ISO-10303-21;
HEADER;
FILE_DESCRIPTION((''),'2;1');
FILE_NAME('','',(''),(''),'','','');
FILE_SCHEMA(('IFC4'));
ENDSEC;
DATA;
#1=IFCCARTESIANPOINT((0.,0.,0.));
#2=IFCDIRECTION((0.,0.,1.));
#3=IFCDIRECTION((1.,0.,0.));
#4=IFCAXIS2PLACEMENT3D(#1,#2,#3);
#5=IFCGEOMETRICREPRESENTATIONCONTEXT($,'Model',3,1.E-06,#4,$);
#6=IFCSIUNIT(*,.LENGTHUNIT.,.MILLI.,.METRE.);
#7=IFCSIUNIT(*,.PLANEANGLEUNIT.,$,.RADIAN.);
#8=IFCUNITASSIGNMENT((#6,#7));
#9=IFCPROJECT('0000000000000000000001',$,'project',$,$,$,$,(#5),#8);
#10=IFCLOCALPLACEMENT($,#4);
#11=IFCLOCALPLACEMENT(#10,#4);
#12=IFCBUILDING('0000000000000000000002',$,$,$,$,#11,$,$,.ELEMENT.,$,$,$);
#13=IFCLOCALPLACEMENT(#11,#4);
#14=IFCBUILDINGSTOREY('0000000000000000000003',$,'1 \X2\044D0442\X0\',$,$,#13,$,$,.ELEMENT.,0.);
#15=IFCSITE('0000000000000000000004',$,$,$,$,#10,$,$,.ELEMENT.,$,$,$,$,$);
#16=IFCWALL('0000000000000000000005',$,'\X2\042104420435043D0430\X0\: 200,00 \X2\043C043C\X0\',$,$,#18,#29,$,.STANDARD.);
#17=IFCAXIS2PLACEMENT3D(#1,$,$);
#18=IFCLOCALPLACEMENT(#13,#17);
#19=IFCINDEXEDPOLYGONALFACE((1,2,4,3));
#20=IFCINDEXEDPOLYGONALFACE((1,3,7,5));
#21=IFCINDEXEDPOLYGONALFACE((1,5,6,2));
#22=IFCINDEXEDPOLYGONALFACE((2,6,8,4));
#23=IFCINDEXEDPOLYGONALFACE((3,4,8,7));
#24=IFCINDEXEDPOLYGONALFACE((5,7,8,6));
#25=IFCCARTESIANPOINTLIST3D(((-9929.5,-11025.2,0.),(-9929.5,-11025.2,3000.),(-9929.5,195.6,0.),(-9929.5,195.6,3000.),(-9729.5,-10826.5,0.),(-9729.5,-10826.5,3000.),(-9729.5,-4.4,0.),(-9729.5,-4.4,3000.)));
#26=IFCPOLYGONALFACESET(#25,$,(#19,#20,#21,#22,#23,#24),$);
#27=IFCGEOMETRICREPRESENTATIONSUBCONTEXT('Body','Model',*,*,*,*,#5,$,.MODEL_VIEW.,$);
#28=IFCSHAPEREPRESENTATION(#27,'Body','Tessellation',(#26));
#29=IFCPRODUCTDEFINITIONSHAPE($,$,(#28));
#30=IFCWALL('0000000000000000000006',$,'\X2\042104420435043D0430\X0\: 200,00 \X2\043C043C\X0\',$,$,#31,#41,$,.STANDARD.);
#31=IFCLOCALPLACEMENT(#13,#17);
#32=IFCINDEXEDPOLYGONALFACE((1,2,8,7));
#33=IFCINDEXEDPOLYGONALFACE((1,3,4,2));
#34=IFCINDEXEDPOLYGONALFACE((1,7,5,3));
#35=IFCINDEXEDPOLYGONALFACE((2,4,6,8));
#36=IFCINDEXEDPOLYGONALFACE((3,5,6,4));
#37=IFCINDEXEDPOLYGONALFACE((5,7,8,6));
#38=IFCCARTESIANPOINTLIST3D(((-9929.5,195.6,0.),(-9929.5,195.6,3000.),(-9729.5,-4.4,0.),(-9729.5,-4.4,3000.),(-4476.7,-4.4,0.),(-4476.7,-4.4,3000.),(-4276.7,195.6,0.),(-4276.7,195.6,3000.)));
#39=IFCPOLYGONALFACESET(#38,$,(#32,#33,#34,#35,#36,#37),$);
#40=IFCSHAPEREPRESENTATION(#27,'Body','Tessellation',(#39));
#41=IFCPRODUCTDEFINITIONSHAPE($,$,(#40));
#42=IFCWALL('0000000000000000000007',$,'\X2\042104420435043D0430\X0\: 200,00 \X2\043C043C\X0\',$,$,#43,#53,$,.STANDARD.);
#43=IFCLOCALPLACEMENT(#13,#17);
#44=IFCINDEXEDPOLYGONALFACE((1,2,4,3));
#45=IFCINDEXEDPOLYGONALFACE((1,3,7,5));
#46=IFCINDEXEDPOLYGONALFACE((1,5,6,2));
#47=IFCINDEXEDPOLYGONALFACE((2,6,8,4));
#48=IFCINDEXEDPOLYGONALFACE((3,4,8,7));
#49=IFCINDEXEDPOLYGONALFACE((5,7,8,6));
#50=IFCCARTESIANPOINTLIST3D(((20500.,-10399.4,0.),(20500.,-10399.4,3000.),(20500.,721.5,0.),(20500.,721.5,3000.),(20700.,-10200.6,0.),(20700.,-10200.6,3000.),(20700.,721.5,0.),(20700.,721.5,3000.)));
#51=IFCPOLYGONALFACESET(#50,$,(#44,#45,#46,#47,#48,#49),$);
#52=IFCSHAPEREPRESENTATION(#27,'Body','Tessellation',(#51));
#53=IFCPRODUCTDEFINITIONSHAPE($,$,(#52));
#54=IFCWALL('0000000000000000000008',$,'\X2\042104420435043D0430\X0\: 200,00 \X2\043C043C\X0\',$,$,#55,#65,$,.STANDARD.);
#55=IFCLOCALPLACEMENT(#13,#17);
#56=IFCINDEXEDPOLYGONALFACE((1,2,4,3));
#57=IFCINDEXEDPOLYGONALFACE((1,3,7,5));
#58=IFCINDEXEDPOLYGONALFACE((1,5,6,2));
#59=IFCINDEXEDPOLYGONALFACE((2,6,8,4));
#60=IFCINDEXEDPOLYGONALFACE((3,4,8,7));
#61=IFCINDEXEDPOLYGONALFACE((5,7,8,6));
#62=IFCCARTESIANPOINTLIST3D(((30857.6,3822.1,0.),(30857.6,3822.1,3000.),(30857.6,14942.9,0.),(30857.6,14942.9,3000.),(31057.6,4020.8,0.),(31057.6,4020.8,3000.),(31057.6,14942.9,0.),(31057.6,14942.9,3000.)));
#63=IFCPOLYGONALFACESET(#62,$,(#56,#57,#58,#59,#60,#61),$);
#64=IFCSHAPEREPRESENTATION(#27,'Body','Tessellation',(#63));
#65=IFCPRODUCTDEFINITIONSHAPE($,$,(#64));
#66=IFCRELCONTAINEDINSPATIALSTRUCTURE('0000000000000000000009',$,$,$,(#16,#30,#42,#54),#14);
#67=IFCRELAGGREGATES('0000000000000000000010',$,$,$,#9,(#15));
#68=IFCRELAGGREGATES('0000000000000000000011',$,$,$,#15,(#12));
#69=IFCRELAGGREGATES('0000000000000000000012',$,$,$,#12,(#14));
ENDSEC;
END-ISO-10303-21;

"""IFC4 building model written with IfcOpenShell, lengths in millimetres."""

from ifc_helpers import new_model, si_unit, frame, origin_with_axes, place, context, subcontext, project, spatial, line, indexed_curve, outline, extrude, source, transform, mapped, element, save


model = new_model("IFC4")

# Units and contexts
model_context = context("Model", 3, precision=1e-06, world=origin_with_axes())
body_context = subcontext(model_context, "Body", "Model", "MODEL_VIEW")
ifc_project = project(units=[si_unit("LENGTHUNIT", "METRE", prefix="MILLI"), si_unit("PLANEANGLEUNIT", "RADIAN")], contexts=[model_context])

# Site, building, storey
site_placement = place(None, origin_with_axes())
site = spatial("IfcSite", under=ifc_project, at=site_placement, CompositionType="ELEMENT")
building_placement = place(site_placement, origin_with_axes())
building = spatial("IfcBuilding", under=site, at=building_placement, CompositionType="ELEMENT")
storey_placement = place(building_placement, origin_with_axes())
storey = spatial("IfcBuildingStorey", under=building, at=storey_placement, Name="1 эт", CompositionType="ELEMENT", Elevation=0.0)

# Walls
shared_shape_1 = source(origin_with_axes(), body_context, "Body", "SweptSolid", [
    extrude(outline(indexed_curve([(99.4, -100.0), (10921.5, -100.0), (11121.5, 100.0), (-99.4, 100.0)], segments=[line(1, 2), line(2, 3), line(3, 4), line(4, 1)])), origin_with_axes(), (0.0, 0.0, 1.0), 3000.0),
])
wall_1_placement = place(storey_placement, frame((-9829.5, -10925.9, 0.0), z_axis=(0.0, 0.0, 1.0), x_axis=(0.0, 1.0, 0.0)))
element("IfcWall", 1, at=wall_1_placement, inside=storey, Name="Стена: 200,00 мм", PredefinedType="STANDARD", context=body_context, shape_type="MappedRepresentation", body=[
    mapped(shared_shape_1, transform((0.0, 0.0, 0.0), x_axis=(1.0, 0.0, 0.0), y_axis=(0.0, 1.0, 0.0), z_axis=(0.0, 0.0, 1.0), scale=1.0)),
])
shared_shape_2 = source(origin_with_axes(), body_context, "Body", "SweptSolid", [
    extrude(outline(indexed_curve([(100.0, -100.0), (5352.8, -100.0), (5552.8, 100.0), (-100.0, 100.0)], segments=[line(1, 2), line(2, 3), line(3, 4), line(4, 1)])), origin_with_axes(), (0.0, 0.0, 1.0), 3000.0),
])
wall_2_placement = place(storey_placement, frame((-9829.5, 95.6, 0.0), z_axis=(0.0, 0.0, 1.0), x_axis=(1.0, 0.0, 0.0)))
element("IfcWall", 2, at=wall_2_placement, inside=storey, Name="Стена: 200,00 мм", PredefinedType="STANDARD", context=body_context, shape_type="MappedRepresentation", body=[
    mapped(shared_shape_2, transform((0.0, 0.0, 0.0), x_axis=(1.0, 0.0, 0.0), y_axis=(0.0, 1.0, 0.0), z_axis=(0.0, 0.0, 1.0), scale=1.0)),
])
shared_shape_3 = source(origin_with_axes(), body_context, "Body", "SweptSolid", [
    extrude(outline(indexed_curve([(99.4, -100.0), (11021.5, -100.0), (11021.5, 100.0), (-99.4, 100.0)], segments=[line(1, 2), line(2, 3), line(3, 4), line(4, 1)])), origin_with_axes(), (0.0, 0.0, 1.0), 3000.0),
])
for number, where, z_axis, x_axis, name in (
    (3, (20600.0, -10300.0, 0.0), (0.0, 0.0, 1.0), (0.0, 1.0, 0.0), "Стена: 200,00 мм"),
    (4, (30957.6, 3921.4, 0.0), (0.0, 0.0, 1.0), (0.0, 1.0, 0.0), "Стена: 200,00 мм"),
):
    element("IfcWall", number, at=place(storey_placement, frame(where, z_axis=z_axis, x_axis=x_axis)), inside=storey, Name=name, PredefinedType="STANDARD", context=body_context, shape_type="MappedRepresentation", body=[
        mapped(shared_shape_3, transform((0.0, 0.0, 0.0), x_axis=(1.0, 0.0, 0.0), y_axis=(0.0, 1.0, 0.0), z_axis=(0.0, 0.0, 1.0), scale=1.0)),
    ])

save(model, "model.ifc")
